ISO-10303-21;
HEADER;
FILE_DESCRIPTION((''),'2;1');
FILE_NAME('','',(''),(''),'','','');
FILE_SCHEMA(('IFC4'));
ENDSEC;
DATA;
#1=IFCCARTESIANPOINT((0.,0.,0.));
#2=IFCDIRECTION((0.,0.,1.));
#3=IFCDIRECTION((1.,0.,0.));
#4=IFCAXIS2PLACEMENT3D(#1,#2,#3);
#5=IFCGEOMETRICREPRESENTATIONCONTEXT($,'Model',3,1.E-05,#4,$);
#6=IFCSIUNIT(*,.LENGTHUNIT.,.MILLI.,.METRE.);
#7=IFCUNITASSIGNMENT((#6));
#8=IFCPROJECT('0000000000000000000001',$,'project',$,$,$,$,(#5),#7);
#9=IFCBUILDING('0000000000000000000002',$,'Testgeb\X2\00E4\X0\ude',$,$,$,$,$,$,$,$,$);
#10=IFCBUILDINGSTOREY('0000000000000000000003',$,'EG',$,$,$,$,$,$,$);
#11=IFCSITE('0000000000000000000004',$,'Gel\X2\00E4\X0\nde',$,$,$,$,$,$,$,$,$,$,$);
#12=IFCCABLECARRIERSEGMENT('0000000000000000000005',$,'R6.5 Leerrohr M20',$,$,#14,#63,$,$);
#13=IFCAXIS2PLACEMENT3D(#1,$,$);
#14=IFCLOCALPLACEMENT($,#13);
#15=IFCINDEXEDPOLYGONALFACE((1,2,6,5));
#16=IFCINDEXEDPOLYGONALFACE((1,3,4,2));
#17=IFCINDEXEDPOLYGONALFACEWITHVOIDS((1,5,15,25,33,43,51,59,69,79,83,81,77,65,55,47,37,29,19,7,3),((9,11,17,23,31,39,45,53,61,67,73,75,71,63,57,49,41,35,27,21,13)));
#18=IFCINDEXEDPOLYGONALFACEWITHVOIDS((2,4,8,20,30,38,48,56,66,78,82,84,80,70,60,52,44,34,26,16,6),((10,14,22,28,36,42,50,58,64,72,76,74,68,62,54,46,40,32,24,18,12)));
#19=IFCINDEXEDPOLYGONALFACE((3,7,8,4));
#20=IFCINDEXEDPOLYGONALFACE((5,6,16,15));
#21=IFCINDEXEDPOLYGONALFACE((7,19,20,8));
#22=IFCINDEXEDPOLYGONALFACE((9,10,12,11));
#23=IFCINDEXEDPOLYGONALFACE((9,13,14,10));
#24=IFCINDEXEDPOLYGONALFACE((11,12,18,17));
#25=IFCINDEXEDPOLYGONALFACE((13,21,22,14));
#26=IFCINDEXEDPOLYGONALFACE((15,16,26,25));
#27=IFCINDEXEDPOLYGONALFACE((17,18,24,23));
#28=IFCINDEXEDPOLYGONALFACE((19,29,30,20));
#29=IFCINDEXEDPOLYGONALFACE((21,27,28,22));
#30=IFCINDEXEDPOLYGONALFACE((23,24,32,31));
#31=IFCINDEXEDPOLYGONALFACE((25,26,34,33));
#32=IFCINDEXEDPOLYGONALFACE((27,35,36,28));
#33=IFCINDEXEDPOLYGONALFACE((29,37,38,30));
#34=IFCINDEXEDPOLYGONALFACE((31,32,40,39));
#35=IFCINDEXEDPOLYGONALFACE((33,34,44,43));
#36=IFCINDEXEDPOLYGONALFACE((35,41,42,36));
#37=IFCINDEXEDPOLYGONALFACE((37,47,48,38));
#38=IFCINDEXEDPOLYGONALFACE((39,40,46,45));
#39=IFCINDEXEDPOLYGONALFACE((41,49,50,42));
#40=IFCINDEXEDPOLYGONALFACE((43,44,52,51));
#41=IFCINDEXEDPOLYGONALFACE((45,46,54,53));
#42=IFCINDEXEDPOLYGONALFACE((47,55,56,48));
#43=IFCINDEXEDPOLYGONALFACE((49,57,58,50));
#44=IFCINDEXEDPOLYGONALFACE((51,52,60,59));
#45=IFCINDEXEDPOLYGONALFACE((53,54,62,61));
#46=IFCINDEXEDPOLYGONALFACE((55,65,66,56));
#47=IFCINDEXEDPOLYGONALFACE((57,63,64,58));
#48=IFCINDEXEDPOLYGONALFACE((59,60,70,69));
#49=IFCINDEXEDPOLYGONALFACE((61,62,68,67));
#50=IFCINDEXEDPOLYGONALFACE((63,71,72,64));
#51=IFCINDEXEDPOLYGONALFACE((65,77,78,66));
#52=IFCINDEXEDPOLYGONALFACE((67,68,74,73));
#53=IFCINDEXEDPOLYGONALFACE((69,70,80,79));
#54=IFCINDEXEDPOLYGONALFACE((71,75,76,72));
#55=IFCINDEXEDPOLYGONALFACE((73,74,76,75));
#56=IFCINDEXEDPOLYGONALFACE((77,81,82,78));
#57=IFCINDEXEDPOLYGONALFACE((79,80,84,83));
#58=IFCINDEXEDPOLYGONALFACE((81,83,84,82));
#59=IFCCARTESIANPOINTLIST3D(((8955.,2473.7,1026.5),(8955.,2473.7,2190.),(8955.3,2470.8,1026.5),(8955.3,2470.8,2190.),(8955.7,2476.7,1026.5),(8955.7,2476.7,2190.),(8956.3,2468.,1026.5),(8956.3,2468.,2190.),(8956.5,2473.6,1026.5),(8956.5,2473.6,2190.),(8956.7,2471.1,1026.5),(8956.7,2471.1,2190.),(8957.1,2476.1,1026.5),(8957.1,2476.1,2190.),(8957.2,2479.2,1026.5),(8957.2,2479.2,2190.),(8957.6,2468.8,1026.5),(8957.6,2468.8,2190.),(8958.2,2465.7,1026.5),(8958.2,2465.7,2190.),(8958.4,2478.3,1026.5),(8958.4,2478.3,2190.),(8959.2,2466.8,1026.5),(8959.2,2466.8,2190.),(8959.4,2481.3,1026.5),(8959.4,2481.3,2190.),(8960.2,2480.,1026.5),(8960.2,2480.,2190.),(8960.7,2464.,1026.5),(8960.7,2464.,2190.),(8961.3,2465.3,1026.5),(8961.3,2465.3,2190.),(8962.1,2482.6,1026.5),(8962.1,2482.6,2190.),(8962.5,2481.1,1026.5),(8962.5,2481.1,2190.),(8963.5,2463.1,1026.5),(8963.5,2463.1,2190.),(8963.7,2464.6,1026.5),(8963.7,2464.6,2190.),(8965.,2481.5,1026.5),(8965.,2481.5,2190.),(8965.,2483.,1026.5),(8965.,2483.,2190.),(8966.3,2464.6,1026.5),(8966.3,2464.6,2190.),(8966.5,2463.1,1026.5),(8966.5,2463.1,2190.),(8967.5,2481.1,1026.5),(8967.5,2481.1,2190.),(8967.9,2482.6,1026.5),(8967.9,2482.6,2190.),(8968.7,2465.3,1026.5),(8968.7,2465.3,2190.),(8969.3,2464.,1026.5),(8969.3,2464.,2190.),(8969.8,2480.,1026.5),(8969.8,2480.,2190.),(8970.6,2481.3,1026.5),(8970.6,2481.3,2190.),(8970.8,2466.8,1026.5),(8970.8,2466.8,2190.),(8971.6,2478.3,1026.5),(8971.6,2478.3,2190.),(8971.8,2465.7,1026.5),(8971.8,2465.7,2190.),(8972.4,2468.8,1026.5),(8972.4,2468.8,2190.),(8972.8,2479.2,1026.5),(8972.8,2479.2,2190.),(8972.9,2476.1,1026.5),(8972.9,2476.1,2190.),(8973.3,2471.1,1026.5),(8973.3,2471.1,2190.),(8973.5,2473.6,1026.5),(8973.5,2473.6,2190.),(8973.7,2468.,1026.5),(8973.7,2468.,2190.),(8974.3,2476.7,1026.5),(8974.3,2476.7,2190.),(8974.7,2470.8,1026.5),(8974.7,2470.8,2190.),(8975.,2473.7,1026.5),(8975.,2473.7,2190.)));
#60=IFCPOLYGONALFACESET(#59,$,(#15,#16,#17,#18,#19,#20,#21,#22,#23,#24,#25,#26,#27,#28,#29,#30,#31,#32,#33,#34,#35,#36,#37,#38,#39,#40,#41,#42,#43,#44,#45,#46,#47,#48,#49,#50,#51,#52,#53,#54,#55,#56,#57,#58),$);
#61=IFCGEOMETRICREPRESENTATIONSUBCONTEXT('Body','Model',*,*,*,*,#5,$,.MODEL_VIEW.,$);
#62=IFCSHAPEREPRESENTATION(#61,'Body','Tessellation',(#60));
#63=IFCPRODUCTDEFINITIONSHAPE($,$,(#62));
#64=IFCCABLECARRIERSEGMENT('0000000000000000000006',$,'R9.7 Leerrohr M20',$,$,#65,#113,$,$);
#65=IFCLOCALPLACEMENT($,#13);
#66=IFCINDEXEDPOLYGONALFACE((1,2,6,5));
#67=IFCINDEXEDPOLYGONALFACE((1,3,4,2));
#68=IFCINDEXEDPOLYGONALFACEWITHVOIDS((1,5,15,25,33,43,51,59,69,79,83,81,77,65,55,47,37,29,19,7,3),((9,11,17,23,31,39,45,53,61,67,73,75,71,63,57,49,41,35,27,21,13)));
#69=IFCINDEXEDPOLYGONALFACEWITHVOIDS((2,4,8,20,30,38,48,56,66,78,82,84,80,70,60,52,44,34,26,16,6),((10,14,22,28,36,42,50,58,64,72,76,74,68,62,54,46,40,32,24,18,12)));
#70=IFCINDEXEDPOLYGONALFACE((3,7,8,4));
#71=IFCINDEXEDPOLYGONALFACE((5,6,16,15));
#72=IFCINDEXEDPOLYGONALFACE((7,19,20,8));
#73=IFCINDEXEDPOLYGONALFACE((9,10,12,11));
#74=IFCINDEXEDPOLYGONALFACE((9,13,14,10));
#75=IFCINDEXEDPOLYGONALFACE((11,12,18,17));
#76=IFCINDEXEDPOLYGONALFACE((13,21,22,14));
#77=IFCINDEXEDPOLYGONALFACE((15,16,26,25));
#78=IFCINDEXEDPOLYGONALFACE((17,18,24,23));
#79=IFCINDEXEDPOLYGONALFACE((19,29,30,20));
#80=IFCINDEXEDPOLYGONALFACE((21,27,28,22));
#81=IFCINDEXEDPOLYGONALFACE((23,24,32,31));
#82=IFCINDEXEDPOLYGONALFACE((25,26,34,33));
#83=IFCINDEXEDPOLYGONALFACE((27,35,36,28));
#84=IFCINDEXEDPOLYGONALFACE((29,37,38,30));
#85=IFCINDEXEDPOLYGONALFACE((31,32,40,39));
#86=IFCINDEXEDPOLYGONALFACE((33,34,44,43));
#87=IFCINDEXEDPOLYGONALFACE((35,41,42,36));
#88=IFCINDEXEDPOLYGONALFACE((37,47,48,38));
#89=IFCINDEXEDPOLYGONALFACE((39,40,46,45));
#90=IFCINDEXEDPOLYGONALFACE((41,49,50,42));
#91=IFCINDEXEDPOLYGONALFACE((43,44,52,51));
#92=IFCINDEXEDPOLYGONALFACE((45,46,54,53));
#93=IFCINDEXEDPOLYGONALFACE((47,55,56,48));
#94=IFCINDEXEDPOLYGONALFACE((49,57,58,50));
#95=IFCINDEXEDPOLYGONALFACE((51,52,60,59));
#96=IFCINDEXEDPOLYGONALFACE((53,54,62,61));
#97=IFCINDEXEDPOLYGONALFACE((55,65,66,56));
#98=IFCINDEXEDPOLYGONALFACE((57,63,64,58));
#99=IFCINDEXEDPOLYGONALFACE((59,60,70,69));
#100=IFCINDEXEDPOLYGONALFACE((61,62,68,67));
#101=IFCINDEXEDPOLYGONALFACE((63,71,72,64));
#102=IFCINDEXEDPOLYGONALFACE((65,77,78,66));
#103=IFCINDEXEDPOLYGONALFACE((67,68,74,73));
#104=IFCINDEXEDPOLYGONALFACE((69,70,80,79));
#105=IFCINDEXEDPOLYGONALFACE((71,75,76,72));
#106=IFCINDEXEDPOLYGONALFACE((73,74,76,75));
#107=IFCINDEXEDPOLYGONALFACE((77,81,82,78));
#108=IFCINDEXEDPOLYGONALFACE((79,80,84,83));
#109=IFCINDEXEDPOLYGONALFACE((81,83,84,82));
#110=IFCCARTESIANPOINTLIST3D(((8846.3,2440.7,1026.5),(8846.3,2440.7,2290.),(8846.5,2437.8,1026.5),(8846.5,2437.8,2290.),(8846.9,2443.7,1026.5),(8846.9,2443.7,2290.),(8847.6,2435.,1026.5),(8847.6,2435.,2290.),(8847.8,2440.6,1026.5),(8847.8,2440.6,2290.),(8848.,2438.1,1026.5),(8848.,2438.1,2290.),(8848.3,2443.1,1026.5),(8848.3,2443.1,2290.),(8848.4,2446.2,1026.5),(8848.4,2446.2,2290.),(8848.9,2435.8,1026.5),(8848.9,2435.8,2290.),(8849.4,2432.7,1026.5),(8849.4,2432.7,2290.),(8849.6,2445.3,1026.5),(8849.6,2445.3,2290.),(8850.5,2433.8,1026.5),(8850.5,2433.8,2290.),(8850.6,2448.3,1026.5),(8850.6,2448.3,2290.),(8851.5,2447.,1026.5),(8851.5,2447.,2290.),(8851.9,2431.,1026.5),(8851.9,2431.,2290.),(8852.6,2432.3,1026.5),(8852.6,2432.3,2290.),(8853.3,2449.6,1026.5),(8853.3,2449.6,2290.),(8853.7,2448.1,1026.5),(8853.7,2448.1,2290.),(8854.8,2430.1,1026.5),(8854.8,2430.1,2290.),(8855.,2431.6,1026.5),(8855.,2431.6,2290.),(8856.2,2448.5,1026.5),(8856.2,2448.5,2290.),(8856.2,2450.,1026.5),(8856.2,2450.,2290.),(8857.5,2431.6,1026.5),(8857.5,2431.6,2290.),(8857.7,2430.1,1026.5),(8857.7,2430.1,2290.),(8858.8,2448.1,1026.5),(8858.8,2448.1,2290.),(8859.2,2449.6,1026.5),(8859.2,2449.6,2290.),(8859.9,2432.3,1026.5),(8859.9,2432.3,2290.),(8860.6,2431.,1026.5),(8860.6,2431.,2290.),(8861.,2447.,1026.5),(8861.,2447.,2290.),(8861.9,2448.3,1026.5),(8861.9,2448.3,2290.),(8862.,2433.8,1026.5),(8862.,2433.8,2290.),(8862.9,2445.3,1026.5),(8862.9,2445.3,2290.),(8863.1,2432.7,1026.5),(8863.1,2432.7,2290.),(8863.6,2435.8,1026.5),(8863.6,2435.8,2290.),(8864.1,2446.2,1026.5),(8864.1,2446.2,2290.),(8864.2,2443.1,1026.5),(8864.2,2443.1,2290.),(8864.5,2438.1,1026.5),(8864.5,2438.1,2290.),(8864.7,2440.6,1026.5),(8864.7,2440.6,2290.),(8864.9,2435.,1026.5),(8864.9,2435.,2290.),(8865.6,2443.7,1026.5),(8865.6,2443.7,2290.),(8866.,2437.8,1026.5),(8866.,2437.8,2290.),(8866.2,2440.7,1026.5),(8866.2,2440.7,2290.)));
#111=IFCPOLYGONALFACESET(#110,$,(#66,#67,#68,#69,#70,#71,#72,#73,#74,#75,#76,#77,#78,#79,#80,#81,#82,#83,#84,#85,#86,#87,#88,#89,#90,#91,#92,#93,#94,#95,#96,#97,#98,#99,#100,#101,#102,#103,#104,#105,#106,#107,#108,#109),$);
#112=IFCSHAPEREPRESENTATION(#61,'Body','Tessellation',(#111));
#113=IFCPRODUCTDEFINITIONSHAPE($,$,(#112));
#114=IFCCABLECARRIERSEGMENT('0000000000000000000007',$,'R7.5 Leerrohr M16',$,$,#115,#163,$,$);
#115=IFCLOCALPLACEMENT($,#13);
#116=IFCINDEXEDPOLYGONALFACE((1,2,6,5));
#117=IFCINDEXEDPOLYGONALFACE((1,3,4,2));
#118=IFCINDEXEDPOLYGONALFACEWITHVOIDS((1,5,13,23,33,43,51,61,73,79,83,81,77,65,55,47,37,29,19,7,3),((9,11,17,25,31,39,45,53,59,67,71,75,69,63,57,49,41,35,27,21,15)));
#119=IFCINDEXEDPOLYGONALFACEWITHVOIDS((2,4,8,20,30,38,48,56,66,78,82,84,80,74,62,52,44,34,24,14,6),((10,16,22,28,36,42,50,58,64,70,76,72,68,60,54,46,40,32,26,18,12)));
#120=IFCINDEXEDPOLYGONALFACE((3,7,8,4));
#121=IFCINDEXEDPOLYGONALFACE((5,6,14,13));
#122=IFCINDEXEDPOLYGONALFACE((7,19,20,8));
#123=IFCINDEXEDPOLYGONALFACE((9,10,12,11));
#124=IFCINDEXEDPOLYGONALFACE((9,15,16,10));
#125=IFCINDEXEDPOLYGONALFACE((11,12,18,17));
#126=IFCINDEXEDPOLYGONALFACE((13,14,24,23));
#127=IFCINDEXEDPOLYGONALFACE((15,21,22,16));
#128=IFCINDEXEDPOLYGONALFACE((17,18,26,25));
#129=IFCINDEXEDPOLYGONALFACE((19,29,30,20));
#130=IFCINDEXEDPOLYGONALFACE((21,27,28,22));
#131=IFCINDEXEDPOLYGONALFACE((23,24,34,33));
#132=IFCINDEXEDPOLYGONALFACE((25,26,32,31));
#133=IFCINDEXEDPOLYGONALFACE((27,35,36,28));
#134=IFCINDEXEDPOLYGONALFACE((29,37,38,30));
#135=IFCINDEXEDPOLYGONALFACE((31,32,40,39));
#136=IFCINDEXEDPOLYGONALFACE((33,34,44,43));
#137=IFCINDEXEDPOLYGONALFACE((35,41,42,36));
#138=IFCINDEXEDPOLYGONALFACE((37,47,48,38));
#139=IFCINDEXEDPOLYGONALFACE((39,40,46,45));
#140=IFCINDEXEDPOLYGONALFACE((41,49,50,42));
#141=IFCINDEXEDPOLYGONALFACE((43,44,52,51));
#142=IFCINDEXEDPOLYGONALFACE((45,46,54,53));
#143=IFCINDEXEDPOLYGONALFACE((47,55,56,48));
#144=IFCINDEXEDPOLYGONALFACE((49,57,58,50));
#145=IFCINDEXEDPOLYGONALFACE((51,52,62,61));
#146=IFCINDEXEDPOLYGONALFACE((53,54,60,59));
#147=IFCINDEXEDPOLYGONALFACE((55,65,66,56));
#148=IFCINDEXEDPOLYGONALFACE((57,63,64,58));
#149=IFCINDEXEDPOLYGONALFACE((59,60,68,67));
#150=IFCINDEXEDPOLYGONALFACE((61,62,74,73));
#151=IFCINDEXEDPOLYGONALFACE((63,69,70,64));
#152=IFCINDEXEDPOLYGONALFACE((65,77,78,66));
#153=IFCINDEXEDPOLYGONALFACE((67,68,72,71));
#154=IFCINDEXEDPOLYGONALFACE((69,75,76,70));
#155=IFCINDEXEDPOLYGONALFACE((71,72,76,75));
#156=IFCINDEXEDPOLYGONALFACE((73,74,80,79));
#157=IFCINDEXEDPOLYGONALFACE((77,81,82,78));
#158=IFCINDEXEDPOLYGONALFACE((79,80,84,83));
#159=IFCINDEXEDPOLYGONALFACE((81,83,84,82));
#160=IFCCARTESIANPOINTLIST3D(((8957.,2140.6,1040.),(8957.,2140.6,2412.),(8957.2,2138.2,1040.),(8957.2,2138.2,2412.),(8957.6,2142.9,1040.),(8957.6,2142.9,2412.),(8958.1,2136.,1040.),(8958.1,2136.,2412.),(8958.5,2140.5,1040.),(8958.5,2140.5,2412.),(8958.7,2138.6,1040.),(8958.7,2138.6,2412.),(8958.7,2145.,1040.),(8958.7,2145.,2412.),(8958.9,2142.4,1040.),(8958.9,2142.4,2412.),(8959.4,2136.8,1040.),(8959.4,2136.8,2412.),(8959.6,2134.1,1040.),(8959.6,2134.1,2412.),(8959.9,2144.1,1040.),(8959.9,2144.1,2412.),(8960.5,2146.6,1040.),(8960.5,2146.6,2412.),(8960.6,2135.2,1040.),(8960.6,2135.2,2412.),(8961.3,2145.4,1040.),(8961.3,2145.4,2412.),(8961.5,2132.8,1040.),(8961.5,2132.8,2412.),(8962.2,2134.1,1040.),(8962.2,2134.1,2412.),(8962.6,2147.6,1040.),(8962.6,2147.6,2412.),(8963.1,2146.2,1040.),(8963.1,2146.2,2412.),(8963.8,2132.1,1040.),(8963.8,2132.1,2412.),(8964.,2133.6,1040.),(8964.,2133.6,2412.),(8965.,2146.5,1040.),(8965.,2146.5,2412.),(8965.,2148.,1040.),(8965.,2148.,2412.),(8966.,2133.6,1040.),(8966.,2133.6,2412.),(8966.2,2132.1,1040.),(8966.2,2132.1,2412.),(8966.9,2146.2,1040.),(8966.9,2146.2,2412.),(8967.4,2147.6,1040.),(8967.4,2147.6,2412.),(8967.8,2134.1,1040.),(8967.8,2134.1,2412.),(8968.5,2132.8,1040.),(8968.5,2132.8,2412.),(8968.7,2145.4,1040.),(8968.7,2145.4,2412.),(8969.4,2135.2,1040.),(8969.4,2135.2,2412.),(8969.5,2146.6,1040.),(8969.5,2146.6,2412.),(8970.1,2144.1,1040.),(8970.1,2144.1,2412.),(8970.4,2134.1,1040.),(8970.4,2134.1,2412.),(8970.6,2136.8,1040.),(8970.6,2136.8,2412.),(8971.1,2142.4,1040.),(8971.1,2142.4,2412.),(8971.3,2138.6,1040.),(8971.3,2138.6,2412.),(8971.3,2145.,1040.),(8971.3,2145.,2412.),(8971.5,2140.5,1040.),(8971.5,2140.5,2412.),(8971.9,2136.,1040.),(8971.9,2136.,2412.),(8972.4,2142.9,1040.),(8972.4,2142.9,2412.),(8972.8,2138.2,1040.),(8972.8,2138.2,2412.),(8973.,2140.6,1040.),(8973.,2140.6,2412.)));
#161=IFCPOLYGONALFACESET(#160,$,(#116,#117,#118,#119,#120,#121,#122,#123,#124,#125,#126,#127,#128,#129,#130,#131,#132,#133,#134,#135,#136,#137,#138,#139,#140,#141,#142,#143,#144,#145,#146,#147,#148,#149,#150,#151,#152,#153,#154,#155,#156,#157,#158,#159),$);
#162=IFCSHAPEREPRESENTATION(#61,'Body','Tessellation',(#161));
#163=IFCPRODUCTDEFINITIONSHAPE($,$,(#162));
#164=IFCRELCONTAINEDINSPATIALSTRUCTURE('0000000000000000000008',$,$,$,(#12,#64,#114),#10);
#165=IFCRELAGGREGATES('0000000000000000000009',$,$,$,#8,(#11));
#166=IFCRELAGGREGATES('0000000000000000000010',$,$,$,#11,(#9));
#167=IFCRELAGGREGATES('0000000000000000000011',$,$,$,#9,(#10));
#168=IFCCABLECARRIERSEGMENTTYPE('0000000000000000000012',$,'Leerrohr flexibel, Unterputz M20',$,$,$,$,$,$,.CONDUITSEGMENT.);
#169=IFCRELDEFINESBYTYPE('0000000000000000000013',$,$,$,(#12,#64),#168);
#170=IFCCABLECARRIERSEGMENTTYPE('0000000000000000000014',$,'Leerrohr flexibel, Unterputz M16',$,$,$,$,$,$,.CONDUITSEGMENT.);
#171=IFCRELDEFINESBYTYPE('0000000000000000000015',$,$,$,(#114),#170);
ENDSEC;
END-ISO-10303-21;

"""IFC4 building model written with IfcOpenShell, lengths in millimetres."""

from ifc_helpers import new_model, si_unit, frame, origin_with_axes, place, context, subcontext, project, spatial, hollow_circle, extrude, type_object, element, save


model = new_model("IFC4")

# Units and contexts
model_context = context("Model", 3, precision=1e-05, world=origin_with_axes())
body_context = subcontext(model_context, "Body", "Model", "MODEL_VIEW")
ifc_project = project(units=[si_unit("LENGTHUNIT", "METRE", prefix="MILLI")], contexts=[model_context])

# Site, building, storey
site = spatial("IfcSite", under=ifc_project, Name="Gelände")
building = spatial("IfcBuilding", under=site, Name="Testgebäude")
storey = spatial("IfcBuildingStorey", under=building, Name="EG")

# Cable carrier segments
cable_carrier_segment_type_1 = type_object("IfcCableCarrierSegmentType", Name="Leerrohr flexibel, Unterputz M20", PredefinedType="CONDUITSEGMENT")
cable_carrier_segment_1_placement = place(None, frame((8965.0, 2473.0, 2190.0), z_axis=(0.0, 0.0, -1.0), x_axis=(0.0, 1.0, 0.0)))
element("IfcCableCarrierSegment", 1, at=cable_carrier_segment_1_placement, inside=storey, type_object=cable_carrier_segment_type_1, Name="R6.5 Leerrohr M20", context=body_context, shape_type="SweptSolid", body=[
    extrude(hollow_circle(Radius=10.0, WallThickness=1.5), None, (0.0, 0.0, 1.0), 1163.5),
])
cable_carrier_segment_2_placement = place(None, frame((8856.2, 2440.0, 2290.0), z_axis=(0.0, 0.0, -1.0), x_axis=(0.0, 1.0, 0.0)))
element("IfcCableCarrierSegment", 2, at=cable_carrier_segment_2_placement, inside=storey, type_object=cable_carrier_segment_type_1, Name="R9.7 Leerrohr M20", context=body_context, shape_type="SweptSolid", body=[
    extrude(hollow_circle(Radius=10.0, WallThickness=1.5), None, (0.0, 0.0, 1.0), 1263.5),
])

# Cable carrier segment
cable_carrier_segment_type_2 = type_object("IfcCableCarrierSegmentType", Name="Leerrohr flexibel, Unterputz M16", PredefinedType="CONDUITSEGMENT")
cable_carrier_segment_3_placement = place(None, frame((8965.0, 2140.0, 2412.0), z_axis=(0.0, 0.0, -1.0), x_axis=(0.0, 1.0, 0.0)))
element("IfcCableCarrierSegment", 3, at=cable_carrier_segment_3_placement, inside=storey, type_object=cable_carrier_segment_type_2, Name="R7.5 Leerrohr M16", context=body_context, shape_type="SweptSolid", body=[
    extrude(hollow_circle(Radius=8.0, WallThickness=1.5), None, (0.0, 0.0, 1.0), 1372.0),
])

save(model, "model.ifc")
